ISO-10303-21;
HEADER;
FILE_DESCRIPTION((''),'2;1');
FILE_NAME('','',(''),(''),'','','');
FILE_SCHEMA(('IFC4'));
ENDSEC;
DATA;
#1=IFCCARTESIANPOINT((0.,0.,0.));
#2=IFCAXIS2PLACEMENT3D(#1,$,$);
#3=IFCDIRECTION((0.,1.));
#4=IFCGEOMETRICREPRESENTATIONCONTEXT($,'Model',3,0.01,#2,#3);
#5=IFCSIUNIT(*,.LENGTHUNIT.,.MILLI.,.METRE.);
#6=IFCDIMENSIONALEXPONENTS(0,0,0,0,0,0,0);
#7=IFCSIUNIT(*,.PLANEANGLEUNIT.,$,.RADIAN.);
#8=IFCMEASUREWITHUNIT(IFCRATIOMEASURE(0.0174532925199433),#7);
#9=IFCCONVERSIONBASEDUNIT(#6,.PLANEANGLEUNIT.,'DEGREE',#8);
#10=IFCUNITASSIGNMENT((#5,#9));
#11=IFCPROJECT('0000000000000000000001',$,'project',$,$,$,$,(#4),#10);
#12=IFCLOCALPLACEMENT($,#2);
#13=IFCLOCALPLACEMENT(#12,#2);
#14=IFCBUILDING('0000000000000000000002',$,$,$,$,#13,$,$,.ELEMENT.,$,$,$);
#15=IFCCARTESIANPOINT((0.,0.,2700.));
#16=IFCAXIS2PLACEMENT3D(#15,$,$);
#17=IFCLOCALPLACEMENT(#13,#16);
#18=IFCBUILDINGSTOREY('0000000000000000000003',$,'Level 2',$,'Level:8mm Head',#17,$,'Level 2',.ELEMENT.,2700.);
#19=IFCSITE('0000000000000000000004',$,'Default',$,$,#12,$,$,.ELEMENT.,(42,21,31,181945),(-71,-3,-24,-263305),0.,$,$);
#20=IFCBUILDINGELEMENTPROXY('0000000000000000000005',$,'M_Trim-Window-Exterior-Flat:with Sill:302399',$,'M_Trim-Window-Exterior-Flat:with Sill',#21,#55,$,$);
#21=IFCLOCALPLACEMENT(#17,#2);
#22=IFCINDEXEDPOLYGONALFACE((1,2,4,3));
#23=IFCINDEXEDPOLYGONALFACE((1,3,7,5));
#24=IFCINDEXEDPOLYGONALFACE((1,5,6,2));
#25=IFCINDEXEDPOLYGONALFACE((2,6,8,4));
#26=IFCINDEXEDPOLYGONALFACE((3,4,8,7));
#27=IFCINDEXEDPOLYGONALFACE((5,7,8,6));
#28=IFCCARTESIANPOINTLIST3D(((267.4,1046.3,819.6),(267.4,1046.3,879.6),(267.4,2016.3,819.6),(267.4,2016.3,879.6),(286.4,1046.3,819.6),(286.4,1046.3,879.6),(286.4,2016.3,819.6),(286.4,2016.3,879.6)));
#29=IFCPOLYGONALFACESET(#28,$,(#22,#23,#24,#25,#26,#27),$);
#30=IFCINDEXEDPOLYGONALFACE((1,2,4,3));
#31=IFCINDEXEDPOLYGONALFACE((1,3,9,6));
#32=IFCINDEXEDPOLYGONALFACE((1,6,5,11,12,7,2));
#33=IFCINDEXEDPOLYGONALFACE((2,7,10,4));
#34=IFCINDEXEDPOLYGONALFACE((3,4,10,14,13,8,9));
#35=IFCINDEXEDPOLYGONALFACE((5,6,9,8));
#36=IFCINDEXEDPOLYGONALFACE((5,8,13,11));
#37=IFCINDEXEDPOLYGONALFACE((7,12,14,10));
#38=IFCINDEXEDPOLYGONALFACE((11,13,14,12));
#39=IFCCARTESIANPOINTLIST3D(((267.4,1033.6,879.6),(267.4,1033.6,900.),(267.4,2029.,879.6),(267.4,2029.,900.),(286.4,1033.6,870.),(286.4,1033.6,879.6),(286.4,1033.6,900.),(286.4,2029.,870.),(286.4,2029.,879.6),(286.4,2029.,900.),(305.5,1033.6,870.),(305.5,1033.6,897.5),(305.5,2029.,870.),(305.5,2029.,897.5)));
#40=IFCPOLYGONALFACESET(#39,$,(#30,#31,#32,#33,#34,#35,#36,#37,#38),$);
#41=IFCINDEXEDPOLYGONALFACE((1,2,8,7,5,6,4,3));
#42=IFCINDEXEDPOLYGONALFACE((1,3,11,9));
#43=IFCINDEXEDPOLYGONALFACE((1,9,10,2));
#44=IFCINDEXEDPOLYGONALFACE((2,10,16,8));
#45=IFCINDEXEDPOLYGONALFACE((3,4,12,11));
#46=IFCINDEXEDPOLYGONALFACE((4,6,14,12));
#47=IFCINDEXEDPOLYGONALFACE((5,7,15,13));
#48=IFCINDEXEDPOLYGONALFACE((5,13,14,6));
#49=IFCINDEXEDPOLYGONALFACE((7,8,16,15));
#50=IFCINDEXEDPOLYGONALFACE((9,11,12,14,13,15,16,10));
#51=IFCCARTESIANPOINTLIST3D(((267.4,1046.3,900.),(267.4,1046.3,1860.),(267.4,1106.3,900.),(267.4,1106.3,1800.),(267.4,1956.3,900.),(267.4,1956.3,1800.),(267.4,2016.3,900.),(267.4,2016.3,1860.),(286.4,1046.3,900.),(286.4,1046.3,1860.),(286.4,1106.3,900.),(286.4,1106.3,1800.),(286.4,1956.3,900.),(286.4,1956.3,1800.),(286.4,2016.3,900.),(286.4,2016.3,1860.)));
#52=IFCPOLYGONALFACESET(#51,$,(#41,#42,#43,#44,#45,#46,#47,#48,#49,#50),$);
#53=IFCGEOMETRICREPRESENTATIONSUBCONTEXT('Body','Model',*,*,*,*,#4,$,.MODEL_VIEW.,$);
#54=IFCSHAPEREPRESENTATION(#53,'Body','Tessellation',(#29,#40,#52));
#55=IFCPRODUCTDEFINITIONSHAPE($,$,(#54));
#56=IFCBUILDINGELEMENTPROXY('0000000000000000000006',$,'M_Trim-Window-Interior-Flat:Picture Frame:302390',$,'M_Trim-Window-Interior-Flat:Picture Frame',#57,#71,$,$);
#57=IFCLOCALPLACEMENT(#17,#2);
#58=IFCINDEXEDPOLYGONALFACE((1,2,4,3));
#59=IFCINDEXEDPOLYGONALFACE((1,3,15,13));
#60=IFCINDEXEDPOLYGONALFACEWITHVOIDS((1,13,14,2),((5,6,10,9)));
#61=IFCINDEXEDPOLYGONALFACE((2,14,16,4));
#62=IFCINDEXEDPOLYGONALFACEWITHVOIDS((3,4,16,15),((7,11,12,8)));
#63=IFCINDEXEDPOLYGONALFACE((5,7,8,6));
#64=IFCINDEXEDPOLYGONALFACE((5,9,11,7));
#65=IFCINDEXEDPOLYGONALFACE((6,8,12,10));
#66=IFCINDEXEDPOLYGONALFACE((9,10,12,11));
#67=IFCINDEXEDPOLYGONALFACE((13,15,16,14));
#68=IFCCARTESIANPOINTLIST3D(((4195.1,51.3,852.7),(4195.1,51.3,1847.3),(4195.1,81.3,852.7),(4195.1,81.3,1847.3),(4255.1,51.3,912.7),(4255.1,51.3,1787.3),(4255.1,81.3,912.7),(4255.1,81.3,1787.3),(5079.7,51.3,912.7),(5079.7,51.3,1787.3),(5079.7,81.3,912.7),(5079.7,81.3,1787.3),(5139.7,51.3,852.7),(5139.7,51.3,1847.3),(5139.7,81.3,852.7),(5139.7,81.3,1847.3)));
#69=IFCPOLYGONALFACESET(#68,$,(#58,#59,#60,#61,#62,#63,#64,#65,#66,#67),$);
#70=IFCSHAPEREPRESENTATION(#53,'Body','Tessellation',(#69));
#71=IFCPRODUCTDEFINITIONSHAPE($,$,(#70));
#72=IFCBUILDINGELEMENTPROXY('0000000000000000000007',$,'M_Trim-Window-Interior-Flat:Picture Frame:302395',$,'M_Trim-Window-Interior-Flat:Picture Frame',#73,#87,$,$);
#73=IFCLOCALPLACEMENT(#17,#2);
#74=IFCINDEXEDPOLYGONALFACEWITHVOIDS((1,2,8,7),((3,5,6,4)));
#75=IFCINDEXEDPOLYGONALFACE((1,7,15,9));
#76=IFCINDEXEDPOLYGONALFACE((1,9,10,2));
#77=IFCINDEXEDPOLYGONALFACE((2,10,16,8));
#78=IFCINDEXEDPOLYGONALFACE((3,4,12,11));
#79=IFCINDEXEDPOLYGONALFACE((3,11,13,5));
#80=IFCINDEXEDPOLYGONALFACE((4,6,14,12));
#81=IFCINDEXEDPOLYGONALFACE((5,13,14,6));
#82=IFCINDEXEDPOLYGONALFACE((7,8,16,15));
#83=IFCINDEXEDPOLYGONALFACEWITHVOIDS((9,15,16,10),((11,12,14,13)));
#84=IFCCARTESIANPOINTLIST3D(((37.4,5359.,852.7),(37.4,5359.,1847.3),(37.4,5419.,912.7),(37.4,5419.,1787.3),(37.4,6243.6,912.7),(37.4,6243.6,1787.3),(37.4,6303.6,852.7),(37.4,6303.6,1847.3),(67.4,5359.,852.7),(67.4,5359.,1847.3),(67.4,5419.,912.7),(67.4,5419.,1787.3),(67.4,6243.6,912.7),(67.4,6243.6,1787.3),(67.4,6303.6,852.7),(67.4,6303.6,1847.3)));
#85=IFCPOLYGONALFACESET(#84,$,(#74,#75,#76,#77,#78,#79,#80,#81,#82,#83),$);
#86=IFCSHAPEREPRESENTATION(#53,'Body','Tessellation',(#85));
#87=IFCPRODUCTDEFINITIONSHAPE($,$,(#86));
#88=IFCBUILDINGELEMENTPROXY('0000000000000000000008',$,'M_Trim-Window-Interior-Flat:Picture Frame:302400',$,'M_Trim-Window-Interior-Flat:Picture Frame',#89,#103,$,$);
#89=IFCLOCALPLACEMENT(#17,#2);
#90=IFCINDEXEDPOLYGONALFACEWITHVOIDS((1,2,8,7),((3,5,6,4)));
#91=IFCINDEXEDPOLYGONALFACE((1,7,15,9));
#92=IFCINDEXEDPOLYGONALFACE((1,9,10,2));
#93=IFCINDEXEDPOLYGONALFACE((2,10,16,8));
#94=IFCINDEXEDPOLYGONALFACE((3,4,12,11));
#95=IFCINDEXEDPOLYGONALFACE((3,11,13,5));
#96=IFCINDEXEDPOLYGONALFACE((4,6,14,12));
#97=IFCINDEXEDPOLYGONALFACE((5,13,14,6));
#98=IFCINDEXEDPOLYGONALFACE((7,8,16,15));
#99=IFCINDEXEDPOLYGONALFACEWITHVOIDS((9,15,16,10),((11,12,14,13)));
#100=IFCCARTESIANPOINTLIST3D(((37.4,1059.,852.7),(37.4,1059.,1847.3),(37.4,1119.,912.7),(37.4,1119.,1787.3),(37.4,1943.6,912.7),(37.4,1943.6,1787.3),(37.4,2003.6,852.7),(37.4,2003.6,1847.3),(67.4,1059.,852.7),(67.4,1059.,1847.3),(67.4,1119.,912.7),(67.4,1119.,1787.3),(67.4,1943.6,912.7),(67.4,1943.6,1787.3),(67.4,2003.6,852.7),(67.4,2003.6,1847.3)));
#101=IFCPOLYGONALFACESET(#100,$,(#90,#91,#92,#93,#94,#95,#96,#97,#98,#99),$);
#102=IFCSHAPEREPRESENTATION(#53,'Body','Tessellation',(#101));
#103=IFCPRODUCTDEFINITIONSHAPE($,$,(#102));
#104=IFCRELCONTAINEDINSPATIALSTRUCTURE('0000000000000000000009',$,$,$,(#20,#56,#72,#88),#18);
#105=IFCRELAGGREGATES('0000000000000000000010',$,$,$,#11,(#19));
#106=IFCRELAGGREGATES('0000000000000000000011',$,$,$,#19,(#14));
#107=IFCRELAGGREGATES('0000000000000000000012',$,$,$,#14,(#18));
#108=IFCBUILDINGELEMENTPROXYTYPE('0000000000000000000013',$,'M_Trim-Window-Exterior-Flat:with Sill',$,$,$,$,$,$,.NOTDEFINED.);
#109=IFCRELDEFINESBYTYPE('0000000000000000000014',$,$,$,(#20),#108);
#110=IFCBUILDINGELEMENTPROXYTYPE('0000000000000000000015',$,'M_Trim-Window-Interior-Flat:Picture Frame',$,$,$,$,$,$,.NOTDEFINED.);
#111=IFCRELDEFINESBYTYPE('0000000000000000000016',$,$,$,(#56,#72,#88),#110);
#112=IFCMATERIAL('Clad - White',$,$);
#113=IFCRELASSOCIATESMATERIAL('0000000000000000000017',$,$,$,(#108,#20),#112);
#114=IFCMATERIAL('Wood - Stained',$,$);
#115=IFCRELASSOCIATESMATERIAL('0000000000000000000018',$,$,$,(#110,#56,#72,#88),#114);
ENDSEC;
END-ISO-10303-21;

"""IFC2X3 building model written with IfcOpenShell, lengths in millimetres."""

from ifc_helpers import new_model, entity, si_unit, converted_unit, direction, frame, frame_2d, origin, place, context, subcontext, project, spatial, polyline, rectangle, outline, extrude, source, transform, mapped, material, type_object, type_shapes, element, save


model = new_model("IFC2X3")

# Units and contexts
model_context = context("Model", 3, precision=0.01, world=origin(), true_north=direction((0.0, 1.0)))
body_context = subcontext(model_context, "Body", "Model", "MODEL_VIEW")
ifc_project = project(units=[si_unit("LENGTHUNIT", "METRE", prefix="MILLI"), converted_unit("PLANEANGLEUNIT", "DEGREE", entity("IfcRatioMeasure", 0.0174532925199433), si_unit("PLANEANGLEUNIT", "RADIAN"), dimensions=[0, 0, 0, 0, 0, 0, 0])], contexts=[model_context])

# Site, building, storey
site_placement = place(None, origin())
site = spatial("IfcSite", under=ifc_project, at=site_placement, Name="Default", CompositionType="ELEMENT", RefLatitude=(42, 21, 31, 181945), RefLongitude=(-71, -3, -24, -263305), RefElevation=0.0)
building_placement = place(site_placement, origin())
building = spatial("IfcBuilding", under=site, at=building_placement, CompositionType="ELEMENT")
storey_placement = place(building_placement, frame((0.0, 0.0, 2700.0)))
storey = spatial("IfcBuildingStorey", under=building, at=storey_placement, Name="Level 2", ObjectType="Level:8mm Head", LongName="Level 2", CompositionType="ELEMENT", Elevation=2700.0)

# Building element proxies
ifc_material_1 = material(Name="Clad - White")
ifc_material_2 = material(Name="Wood - Stained")
building_element_proxy_type_1 = type_object("IfcBuildingElementProxyType", Name="M_Trim-Window-Exterior-Flat:with Sill", PredefinedType="NOTDEFINED", material=ifc_material_1)
shared_shape_1 = source(origin(), body_context, "Body", "SweptSolid", [
    extrude(rectangle(XDim=970.0, YDim=60.0, at=frame_2d((0.0, 0.0), x_axis=(1.0, 0.0))), frame((0.0, -950.4, 0.0), z_axis=(0.0, 0.0, 1.0), x_axis=(-1.0, 0.0, 0.0)), (0.0, 0.0, 1.0), 19.1),
    extrude(outline(polyline([(-19.0, -15.2), (0.0, -15.2), (0.0, -5.7), (19.0, -5.7), (19.0, 14.8), (0.0, 14.8), (-19.0, 12.3), (-19.0, -15.2)])), frame((-497.7, -914.8, 19.0), z_axis=(1.0, 0.0, 0.0), x_axis=(0.0, 0.0, -1.0)), (0.0, 0.0, 1.0), 995.4),
    extrude(outline(polyline([(-495.0, -485.0), (465.0, -485.0), (465.0, -425.0), (-435.0, -425.0), (-435.0, 425.0), (465.0, 425.0), (465.0, 485.0), (-495.0, 485.0), (-495.0, -485.0)])), frame((0.0, -435.0, 0.0), z_axis=(0.0, 0.0, 1.0), x_axis=(0.0, -1.0, 0.0)), (0.0, 0.0, 1.0), 19.1),
])
type_shapes(building_element_proxy_type_1, [shared_shape_1])
for number, where, z_axis, x_axis, name in (
    (1, (267.4, 1531.3, 1800.0), (1.0, 0.0, 0.0), (0.0, 1.0, 0.0), "M_Trim-Window-Exterior-Flat:with Sill:302399"),
):
    element("IfcBuildingElementProxy", number, at=place(storey_placement, frame(where, z_axis=z_axis, x_axis=x_axis)), inside=storey, type_object=building_element_proxy_type_1, material=ifc_material_1, Name=name, ObjectType="M_Trim-Window-Exterior-Flat:with Sill", context=body_context, shape_type="MappedRepresentation", body=[
        mapped(shared_shape_1, transform((0.0, 0.0, 0.0), scale=1.0)),
    ])
building_element_proxy_type_2 = type_object("IfcBuildingElementProxyType", Name="M_Trim-Window-Interior-Flat:Picture Frame", PredefinedType="NOTDEFINED", material=ifc_material_2)
shared_shape_2 = source(origin(), body_context, "Body", "SweptSolid", [
    extrude(outline(polyline([(-472.3, -497.3), (472.3, -497.3), (472.3, 497.3), (-472.3, 497.3), (-472.3, -497.3)]), holes=[polyline([(-412.3, -437.3), (-412.3, 437.3), (412.3, 437.3), (412.3, -437.3), (-412.3, -437.3)])]), frame((0.0, -450.0, 0.0), z_axis=(0.0, 0.0, 1.0), x_axis=(-1.0, 0.0, 0.0)), (0.0, 0.0, 1.0), 30.0),
])
type_shapes(building_element_proxy_type_2, [shared_shape_2])
for number, where, z_axis, x_axis, name in (
    (2, (4667.4, 81.3, 1800.0), (0.0, -1.0, 0.0), (1.0, 0.0, 0.0), "M_Trim-Window-Interior-Flat:Picture Frame:302390"),
    (3, (67.4, 5831.3, 1800.0), (-1.0, 0.0, 0.0), (0.0, -1.0, 0.0), "M_Trim-Window-Interior-Flat:Picture Frame:302395"),
    (4, (67.4, 1531.3, 1800.0), (-1.0, 0.0, 0.0), (0.0, -1.0, 0.0), "M_Trim-Window-Interior-Flat:Picture Frame:302400"),
):
    element("IfcBuildingElementProxy", number, at=place(storey_placement, frame(where, z_axis=z_axis, x_axis=x_axis)), inside=storey, type_object=building_element_proxy_type_2, material=ifc_material_2, Name=name, ObjectType="M_Trim-Window-Interior-Flat:Picture Frame", context=body_context, shape_type="MappedRepresentation", body=[
        mapped(shared_shape_2, transform((0.0, 0.0, 0.0), scale=1.0)),
    ])

save(model, "model.ifc")
